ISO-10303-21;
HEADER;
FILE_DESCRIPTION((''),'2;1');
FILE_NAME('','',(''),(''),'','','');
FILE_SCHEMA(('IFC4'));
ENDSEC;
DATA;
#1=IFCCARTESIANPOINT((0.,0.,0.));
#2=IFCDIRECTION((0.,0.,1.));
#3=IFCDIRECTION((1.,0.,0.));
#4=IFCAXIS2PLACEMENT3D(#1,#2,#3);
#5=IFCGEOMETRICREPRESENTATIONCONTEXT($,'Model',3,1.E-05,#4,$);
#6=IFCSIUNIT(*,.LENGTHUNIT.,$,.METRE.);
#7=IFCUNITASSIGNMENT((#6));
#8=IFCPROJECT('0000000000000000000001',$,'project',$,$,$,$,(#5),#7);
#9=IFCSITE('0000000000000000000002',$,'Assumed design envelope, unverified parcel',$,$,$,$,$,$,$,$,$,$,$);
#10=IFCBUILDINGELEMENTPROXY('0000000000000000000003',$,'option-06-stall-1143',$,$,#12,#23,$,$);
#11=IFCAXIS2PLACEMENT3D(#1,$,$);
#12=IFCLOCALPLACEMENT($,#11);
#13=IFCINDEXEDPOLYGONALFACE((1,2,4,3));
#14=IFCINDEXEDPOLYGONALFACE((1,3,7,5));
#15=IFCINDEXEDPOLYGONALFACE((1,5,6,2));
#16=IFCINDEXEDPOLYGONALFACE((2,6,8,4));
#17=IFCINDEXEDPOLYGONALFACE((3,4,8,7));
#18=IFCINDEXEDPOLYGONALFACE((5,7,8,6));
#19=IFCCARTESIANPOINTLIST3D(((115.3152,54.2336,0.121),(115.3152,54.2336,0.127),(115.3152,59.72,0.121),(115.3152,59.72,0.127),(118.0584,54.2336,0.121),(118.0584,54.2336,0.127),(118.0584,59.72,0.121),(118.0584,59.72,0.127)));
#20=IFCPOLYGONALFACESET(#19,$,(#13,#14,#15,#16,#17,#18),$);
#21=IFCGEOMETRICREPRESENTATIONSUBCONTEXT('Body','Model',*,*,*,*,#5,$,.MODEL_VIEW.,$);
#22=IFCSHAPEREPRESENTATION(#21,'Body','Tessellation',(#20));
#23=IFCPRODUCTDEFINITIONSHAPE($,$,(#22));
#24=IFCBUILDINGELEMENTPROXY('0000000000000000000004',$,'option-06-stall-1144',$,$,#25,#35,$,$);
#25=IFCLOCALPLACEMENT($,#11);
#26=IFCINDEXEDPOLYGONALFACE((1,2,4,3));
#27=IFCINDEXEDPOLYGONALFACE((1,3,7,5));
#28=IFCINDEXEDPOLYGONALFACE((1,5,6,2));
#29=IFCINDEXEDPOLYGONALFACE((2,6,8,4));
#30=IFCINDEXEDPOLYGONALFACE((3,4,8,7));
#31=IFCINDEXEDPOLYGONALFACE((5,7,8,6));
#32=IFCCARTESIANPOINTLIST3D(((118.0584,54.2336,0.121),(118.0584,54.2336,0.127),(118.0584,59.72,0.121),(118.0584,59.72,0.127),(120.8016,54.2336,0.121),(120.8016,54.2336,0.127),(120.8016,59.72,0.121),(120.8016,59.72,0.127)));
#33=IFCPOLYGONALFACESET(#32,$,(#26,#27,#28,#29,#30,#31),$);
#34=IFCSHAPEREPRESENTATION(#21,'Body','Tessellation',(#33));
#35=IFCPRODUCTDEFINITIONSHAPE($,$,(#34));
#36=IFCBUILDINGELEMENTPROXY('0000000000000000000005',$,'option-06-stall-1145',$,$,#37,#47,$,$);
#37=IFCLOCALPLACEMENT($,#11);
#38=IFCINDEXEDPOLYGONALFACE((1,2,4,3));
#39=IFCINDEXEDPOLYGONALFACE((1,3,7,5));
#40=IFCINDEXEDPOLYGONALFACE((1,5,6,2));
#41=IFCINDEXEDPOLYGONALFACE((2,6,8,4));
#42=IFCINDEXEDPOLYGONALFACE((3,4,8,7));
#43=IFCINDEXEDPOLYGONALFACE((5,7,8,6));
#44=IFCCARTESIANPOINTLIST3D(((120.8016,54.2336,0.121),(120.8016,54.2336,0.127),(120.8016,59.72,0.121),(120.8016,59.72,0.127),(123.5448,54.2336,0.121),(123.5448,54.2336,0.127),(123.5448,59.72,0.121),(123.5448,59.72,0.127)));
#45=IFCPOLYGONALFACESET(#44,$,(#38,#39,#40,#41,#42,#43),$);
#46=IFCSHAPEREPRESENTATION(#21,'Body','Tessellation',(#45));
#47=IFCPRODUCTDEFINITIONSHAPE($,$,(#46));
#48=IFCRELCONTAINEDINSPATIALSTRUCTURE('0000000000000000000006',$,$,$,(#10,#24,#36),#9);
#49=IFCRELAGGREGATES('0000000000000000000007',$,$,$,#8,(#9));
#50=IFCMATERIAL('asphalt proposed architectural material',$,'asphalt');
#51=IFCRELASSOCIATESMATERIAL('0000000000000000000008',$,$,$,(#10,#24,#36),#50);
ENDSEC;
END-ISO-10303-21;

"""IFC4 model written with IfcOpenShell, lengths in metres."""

from ifc_helpers import new_model, si_unit, frame, origin_with_axes, place, context, subcontext, project, spatial, rectangle, extrude, material, element, save


model = new_model("IFC4")

# Units and contexts
model_context = context("Model", 3, precision=1e-05, world=origin_with_axes())
body_context = subcontext(model_context, "Body", "Model", "MODEL_VIEW")
ifc_project = project(units=[si_unit("LENGTHUNIT", "METRE")], contexts=[model_context])

# Site
site = spatial("IfcSite", under=ifc_project, Name="Assumed design envelope, unverified parcel")

# Building element proxies
ifc_material = material(Name="asphalt proposed architectural material", Category="asphalt")
for number, where, z_axis, x_axis, name in (
    (1, (116.6868, 56.9768, 0.121), (0.0, 0.0, 1.0), (1.0, 0.0, 0.0), "option-06-stall-1143"),
    (2, (119.43, 56.9768, 0.121), (0.0, 0.0, 1.0), (1.0, 0.0, 0.0), "option-06-stall-1144"),
    (3, (122.1732, 56.9768, 0.121), (0.0, 0.0, 1.0), (1.0, 0.0, 0.0), "option-06-stall-1145"),
):
    element("IfcBuildingElementProxy", number, at=place(None, frame(where, z_axis=z_axis, x_axis=x_axis)), inside=site, material=ifc_material, Name=name, context=body_context, shape_type="SweptSolid", body=[
        extrude(rectangle(XDim=2.7432, YDim=5.4864), origin_with_axes(), (0.0, 0.0, 1.0), 0.006),
    ])

save(model, "model.ifc")
